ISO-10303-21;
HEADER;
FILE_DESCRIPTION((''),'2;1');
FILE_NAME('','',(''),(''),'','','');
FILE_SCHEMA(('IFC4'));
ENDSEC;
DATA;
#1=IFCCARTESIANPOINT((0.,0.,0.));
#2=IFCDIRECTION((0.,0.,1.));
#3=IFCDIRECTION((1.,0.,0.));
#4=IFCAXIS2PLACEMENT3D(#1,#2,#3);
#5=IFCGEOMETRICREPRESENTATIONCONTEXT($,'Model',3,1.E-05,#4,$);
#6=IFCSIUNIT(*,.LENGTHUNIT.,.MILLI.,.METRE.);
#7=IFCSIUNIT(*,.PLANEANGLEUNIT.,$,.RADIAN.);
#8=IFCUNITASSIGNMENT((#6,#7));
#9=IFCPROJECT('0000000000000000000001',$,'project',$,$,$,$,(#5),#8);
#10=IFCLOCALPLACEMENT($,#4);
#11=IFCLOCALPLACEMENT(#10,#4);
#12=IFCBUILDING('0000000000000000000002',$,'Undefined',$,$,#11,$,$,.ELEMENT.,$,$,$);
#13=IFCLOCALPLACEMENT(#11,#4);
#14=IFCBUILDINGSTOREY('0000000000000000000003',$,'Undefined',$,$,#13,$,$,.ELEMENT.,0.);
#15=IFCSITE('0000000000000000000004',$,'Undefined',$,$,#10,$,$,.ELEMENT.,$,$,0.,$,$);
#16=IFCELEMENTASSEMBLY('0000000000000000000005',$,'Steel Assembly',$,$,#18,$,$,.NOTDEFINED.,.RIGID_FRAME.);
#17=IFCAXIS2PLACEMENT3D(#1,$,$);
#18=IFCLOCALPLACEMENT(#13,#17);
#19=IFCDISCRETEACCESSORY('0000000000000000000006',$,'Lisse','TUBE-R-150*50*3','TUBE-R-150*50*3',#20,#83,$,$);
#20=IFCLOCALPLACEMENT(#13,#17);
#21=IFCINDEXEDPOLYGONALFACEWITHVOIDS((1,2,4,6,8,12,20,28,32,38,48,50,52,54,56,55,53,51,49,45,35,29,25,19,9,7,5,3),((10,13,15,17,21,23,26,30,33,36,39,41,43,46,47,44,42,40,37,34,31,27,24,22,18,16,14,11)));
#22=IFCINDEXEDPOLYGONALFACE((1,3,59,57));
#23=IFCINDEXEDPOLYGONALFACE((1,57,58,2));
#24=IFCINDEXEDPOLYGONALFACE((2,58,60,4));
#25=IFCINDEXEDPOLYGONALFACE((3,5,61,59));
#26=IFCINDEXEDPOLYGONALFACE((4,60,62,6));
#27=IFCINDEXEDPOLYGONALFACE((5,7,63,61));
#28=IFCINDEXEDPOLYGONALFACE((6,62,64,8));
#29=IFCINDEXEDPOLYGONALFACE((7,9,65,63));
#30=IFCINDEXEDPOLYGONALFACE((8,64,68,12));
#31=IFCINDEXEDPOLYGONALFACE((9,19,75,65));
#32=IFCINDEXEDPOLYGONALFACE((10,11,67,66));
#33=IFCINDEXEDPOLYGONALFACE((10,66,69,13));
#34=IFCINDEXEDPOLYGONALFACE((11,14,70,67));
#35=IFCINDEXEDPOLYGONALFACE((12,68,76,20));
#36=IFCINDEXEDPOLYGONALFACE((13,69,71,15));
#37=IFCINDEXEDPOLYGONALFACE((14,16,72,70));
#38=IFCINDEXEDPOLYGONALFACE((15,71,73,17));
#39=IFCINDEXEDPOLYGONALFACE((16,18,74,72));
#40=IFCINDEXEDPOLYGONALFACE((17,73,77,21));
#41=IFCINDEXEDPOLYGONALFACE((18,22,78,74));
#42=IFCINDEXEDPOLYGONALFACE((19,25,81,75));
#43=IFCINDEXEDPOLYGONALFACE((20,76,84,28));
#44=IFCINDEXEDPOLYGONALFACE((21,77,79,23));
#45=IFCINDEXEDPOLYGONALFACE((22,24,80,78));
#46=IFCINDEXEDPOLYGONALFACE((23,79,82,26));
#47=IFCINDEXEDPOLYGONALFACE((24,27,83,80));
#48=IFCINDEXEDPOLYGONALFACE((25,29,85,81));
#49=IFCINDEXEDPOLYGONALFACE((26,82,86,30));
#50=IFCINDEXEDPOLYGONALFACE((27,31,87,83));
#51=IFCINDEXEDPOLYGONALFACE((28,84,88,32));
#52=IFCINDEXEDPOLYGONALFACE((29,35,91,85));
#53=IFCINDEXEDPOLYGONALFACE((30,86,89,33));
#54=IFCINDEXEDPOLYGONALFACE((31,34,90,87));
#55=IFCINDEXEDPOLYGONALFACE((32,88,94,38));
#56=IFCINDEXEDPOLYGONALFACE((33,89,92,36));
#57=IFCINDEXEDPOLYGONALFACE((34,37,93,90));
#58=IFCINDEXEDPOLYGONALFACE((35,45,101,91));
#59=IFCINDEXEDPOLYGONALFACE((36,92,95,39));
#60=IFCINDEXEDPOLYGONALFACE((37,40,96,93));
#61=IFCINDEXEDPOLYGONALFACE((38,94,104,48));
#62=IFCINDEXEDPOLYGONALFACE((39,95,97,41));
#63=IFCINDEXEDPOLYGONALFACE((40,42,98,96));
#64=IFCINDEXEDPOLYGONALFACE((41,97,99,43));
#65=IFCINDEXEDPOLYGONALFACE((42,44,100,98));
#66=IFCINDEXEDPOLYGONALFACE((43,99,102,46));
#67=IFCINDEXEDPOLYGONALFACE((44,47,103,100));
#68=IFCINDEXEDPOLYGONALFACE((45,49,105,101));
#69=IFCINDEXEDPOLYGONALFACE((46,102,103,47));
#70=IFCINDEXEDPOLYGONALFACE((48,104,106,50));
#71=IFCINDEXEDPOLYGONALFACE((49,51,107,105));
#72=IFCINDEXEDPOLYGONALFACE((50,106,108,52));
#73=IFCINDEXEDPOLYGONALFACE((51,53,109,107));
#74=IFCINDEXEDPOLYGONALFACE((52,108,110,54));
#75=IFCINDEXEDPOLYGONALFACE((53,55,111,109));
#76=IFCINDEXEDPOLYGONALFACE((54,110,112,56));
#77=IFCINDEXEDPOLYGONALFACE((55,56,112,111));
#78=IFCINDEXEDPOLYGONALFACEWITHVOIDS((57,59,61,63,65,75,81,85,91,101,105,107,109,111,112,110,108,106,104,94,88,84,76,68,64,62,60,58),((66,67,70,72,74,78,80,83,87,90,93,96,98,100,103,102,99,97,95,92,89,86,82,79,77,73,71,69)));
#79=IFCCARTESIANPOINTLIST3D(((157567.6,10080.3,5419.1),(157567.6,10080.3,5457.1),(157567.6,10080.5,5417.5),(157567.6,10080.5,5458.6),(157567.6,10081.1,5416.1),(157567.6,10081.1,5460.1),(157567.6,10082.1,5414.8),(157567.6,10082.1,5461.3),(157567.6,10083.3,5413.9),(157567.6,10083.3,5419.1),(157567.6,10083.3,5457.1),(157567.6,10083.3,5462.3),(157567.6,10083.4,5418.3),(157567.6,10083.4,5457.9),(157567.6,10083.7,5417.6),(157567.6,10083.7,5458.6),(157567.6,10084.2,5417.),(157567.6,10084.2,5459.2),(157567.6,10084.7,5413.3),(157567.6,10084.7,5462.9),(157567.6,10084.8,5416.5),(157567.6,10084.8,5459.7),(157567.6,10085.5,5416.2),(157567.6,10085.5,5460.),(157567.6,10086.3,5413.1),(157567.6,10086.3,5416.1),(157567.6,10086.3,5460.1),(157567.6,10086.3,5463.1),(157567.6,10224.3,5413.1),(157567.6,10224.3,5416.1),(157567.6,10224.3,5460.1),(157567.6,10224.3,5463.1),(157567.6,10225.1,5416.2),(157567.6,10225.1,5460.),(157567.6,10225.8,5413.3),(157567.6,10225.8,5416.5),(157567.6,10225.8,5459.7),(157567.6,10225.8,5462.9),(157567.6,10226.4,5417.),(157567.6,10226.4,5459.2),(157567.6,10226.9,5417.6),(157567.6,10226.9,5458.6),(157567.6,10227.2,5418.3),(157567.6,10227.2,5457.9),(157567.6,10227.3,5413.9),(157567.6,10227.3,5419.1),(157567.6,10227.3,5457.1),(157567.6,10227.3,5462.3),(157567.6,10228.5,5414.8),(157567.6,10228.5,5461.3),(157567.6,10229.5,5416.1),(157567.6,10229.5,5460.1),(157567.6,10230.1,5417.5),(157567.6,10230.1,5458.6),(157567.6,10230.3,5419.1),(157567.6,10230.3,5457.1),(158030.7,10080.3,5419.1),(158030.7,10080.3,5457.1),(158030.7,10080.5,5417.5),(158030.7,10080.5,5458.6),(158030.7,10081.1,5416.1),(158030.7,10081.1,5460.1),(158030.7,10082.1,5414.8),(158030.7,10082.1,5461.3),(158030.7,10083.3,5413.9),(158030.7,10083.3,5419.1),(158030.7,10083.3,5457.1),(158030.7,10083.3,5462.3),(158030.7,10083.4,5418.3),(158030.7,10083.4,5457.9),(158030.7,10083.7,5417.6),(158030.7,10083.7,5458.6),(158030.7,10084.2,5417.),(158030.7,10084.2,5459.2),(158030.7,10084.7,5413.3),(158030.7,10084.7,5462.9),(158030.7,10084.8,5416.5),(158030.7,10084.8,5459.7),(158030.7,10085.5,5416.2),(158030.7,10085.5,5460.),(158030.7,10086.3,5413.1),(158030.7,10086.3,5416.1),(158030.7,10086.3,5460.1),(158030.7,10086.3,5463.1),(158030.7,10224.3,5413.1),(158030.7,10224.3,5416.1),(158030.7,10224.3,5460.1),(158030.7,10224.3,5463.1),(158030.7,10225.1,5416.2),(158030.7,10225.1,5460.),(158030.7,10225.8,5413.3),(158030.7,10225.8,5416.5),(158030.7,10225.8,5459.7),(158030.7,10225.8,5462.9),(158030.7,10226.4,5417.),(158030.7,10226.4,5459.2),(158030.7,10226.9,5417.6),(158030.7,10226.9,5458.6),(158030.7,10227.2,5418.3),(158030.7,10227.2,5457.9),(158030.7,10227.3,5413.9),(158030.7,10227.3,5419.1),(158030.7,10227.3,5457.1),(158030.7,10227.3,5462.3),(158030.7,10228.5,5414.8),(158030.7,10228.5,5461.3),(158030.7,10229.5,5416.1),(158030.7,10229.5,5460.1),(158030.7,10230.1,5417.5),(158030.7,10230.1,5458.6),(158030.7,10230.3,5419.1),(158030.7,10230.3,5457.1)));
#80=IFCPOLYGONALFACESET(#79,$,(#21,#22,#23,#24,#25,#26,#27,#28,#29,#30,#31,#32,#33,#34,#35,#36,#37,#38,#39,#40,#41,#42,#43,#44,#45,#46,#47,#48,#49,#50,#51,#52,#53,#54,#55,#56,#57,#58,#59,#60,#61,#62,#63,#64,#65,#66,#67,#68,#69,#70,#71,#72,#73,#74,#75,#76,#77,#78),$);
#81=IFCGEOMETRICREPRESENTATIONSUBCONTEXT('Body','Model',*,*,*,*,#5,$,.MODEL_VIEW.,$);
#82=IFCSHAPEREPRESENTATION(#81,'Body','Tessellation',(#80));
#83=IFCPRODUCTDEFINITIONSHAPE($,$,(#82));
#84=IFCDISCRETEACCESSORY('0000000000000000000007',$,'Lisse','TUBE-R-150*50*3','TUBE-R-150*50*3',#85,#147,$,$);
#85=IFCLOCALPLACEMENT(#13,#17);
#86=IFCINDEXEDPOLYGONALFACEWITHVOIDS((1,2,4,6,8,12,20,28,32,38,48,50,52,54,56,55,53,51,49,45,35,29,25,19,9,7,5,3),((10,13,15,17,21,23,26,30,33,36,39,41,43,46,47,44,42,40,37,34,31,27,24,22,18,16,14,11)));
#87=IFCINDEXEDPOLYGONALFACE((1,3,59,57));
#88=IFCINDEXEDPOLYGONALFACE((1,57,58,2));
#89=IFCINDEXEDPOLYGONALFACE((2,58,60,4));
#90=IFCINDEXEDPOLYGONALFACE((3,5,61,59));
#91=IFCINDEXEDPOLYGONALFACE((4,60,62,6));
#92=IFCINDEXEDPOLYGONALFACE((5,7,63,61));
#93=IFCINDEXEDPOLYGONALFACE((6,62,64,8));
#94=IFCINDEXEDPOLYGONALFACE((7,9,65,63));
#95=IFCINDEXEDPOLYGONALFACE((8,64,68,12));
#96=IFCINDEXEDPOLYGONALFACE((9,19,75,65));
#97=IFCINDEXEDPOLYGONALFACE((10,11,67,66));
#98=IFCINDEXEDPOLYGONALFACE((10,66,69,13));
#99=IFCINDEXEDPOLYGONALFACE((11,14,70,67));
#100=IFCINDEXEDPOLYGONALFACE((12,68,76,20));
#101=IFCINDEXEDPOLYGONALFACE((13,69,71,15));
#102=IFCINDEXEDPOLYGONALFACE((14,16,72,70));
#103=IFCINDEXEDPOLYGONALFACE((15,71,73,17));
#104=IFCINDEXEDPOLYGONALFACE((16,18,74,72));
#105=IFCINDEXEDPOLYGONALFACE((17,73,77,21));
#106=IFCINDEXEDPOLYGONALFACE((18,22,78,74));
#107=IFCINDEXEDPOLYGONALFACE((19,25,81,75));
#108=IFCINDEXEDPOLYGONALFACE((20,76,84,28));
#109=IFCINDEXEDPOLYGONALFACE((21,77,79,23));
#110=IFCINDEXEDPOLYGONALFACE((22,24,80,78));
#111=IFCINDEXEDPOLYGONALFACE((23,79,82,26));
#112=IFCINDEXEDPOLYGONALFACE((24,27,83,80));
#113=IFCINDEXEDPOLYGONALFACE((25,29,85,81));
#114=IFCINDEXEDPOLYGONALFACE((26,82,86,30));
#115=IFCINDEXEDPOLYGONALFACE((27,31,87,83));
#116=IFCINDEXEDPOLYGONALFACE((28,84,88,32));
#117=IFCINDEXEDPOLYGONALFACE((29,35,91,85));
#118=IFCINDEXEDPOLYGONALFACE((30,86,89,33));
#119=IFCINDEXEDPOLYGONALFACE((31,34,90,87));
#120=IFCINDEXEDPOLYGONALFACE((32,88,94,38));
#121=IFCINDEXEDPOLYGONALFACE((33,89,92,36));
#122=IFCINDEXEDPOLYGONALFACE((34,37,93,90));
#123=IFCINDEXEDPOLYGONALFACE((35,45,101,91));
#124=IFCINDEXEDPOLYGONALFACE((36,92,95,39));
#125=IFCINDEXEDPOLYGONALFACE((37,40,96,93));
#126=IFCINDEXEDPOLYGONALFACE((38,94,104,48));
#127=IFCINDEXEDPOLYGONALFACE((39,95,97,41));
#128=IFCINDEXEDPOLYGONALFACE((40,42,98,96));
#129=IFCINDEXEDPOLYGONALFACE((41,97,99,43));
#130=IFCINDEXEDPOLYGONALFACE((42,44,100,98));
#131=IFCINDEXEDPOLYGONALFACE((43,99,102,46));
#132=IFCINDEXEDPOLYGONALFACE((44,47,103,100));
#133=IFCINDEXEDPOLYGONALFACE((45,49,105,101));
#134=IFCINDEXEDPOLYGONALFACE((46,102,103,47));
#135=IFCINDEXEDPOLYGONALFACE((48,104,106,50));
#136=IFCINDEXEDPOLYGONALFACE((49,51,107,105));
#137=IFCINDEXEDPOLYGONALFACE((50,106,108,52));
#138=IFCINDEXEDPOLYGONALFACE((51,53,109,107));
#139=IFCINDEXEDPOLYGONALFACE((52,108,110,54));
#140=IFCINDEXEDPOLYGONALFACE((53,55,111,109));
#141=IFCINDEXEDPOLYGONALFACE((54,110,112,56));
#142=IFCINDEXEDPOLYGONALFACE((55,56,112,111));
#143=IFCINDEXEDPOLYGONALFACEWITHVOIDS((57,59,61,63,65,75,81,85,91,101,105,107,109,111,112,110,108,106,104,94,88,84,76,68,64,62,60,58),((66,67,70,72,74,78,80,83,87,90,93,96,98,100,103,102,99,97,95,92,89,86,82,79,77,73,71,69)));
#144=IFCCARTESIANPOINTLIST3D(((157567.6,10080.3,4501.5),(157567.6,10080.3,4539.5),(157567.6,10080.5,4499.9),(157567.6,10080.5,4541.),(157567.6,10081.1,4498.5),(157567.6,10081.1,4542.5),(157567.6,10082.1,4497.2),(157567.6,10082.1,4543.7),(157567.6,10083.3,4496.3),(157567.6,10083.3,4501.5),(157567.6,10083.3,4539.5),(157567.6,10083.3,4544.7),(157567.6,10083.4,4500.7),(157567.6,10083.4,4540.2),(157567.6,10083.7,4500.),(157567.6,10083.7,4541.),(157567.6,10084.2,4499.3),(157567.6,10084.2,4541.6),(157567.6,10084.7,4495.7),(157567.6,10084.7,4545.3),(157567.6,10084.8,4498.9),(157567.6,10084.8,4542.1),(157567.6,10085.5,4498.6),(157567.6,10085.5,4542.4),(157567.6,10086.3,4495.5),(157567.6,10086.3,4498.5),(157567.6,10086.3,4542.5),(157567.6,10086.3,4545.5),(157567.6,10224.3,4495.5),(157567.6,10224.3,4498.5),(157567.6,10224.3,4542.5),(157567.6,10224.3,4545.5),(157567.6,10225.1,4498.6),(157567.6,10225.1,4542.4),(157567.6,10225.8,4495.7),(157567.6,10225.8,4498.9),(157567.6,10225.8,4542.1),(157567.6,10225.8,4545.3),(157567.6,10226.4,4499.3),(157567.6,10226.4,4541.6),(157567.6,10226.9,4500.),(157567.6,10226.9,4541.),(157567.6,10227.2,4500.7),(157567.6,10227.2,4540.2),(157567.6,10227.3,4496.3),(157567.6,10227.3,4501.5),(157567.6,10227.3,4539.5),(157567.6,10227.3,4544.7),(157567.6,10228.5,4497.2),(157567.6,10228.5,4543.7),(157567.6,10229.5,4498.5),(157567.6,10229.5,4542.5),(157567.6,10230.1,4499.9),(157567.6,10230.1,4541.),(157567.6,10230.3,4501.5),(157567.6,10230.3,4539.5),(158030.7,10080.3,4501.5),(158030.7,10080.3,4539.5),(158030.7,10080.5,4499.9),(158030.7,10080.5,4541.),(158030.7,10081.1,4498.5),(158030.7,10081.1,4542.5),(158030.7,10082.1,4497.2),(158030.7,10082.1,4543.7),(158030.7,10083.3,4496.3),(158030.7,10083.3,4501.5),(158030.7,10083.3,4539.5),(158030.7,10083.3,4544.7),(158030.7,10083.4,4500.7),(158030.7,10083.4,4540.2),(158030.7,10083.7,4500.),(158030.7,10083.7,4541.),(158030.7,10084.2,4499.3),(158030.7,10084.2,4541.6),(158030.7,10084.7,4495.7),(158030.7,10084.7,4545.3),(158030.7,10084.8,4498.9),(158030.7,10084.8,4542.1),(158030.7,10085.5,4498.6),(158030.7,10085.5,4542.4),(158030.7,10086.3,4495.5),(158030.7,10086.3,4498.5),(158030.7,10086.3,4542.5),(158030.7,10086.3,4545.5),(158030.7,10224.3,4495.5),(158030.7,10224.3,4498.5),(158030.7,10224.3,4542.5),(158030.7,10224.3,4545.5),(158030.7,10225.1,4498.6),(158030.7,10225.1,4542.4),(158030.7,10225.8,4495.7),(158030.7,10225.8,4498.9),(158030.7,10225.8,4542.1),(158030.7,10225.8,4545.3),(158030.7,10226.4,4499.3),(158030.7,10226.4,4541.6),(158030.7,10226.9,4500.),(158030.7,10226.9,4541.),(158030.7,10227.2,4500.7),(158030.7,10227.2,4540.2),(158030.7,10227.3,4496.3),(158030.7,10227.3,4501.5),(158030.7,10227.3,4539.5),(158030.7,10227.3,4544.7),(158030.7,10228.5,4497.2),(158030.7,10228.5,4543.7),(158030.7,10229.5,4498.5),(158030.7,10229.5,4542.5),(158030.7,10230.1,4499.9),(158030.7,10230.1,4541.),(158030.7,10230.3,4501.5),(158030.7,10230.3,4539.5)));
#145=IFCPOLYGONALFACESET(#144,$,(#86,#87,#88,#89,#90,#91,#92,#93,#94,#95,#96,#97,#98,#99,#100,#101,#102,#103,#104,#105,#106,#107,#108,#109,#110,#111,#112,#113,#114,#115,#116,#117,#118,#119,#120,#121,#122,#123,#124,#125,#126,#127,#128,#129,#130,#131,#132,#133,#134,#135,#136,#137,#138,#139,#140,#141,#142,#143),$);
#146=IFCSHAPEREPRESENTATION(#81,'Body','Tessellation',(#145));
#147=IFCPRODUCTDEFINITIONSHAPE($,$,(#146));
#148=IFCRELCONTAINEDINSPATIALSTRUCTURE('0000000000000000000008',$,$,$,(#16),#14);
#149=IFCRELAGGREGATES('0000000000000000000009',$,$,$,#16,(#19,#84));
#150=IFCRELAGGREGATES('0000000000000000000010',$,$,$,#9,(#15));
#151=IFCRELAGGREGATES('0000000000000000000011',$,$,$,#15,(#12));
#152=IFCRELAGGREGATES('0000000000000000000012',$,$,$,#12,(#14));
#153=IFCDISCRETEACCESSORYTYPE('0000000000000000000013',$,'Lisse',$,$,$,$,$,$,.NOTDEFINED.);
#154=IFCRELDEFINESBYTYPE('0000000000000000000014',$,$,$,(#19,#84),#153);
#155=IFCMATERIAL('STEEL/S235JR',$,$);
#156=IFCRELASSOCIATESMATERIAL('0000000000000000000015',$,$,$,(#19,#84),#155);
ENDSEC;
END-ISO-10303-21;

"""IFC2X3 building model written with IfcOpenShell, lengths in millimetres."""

from ifc_helpers import new_model, si_unit, frame, origin_with_axes, origin_2d_with_axis, place, context, subcontext, project, spatial, hollow_rectangle, extrude, material, type_object, element, aggregate, save


model = new_model("IFC2X3")

# Units and contexts
model_context = context("Model", 3, precision=1e-05, world=origin_with_axes())
body_context = subcontext(model_context, "Body", "Model", "MODEL_VIEW")
ifc_project = project(units=[si_unit("LENGTHUNIT", "METRE", prefix="MILLI"), si_unit("PLANEANGLEUNIT", "RADIAN")], contexts=[model_context])

# Site, building, storey
site_placement = place(None, origin_with_axes())
site = spatial("IfcSite", under=ifc_project, at=site_placement, Name="Undefined", CompositionType="ELEMENT", RefElevation=0.0)
building_placement = place(site_placement, origin_with_axes())
building = spatial("IfcBuilding", under=site, at=building_placement, Name="Undefined", CompositionType="ELEMENT")
storey_placement = place(building_placement, origin_with_axes())
storey = spatial("IfcBuildingStorey", under=building, at=storey_placement, Name="Undefined", CompositionType="ELEMENT", Elevation=0.0)

# Element assembly
assembly_1_placement = place(storey_placement, origin_with_axes())
assembly_1 = element("IfcElementAssembly", 1, at=assembly_1_placement, inside=storey, Name="Steel Assembly", AssemblyPlace="NOTDEFINED", PredefinedType="RIGID_FRAME")
ifc_material_1 = material(Name="STEEL/S235JR")

# Shared definitions
discrete_accessory_type_1 = type_object("IfcDiscreteAccessoryType", Name="Lisse")

# Discrete accessories
discrete_accessory_1_placement = place(assembly_1_placement, frame((158030.7, 10155.3, 5438.1), z_axis=(0.0, 1.0, 0.0), x_axis=(-1.0, 0.0, 0.0)))
discrete_accessory_1 = element("IfcDiscreteAccessory", 2, at=discrete_accessory_1_placement, type_object=discrete_accessory_type_1, material=ifc_material_1, Name="Lisse", Description="TUBE-R-150*50*3", ObjectType="TUBE-R-150*50*3", context=body_context, shape_type="SweptSolid", body=[
    extrude(hollow_rectangle(XDim=50.0, YDim=150.0, WallThickness=3.0, InnerFilletRadius=3.0, OuterFilletRadius=6.0, at=origin_2d_with_axis()), frame((463.1, 0.0, 0.0), z_axis=(-1.0, 0.0, 0.0), x_axis=(0.0, -1.0, 0.0)), (0.0, 0.0, 1.0), 463.1),
])
discrete_accessory_2_placement = place(assembly_1_placement, frame((158030.7, 10155.3, 4520.5), z_axis=(0.0, 1.0, 0.0), x_axis=(-1.0, 0.0, 0.0)))
discrete_accessory_2 = element("IfcDiscreteAccessory", 3, at=discrete_accessory_2_placement, type_object=discrete_accessory_type_1, material=ifc_material_1, Name="Lisse", Description="TUBE-R-150*50*3", ObjectType="TUBE-R-150*50*3", context=body_context, shape_type="SweptSolid", body=[
    extrude(hollow_rectangle(XDim=50.0, YDim=150.0, WallThickness=3.0, InnerFilletRadius=3.0, OuterFilletRadius=6.0, at=origin_2d_with_axis()), frame((463.1, 0.0, 0.0), z_axis=(-1.0, 0.0, 0.0), x_axis=(0.0, -1.0, 0.0)), (0.0, 0.0, 1.0), 463.1),
])
aggregate(assembly_1, [discrete_accessory_1, discrete_accessory_2])

save(model, "model.ifc")
